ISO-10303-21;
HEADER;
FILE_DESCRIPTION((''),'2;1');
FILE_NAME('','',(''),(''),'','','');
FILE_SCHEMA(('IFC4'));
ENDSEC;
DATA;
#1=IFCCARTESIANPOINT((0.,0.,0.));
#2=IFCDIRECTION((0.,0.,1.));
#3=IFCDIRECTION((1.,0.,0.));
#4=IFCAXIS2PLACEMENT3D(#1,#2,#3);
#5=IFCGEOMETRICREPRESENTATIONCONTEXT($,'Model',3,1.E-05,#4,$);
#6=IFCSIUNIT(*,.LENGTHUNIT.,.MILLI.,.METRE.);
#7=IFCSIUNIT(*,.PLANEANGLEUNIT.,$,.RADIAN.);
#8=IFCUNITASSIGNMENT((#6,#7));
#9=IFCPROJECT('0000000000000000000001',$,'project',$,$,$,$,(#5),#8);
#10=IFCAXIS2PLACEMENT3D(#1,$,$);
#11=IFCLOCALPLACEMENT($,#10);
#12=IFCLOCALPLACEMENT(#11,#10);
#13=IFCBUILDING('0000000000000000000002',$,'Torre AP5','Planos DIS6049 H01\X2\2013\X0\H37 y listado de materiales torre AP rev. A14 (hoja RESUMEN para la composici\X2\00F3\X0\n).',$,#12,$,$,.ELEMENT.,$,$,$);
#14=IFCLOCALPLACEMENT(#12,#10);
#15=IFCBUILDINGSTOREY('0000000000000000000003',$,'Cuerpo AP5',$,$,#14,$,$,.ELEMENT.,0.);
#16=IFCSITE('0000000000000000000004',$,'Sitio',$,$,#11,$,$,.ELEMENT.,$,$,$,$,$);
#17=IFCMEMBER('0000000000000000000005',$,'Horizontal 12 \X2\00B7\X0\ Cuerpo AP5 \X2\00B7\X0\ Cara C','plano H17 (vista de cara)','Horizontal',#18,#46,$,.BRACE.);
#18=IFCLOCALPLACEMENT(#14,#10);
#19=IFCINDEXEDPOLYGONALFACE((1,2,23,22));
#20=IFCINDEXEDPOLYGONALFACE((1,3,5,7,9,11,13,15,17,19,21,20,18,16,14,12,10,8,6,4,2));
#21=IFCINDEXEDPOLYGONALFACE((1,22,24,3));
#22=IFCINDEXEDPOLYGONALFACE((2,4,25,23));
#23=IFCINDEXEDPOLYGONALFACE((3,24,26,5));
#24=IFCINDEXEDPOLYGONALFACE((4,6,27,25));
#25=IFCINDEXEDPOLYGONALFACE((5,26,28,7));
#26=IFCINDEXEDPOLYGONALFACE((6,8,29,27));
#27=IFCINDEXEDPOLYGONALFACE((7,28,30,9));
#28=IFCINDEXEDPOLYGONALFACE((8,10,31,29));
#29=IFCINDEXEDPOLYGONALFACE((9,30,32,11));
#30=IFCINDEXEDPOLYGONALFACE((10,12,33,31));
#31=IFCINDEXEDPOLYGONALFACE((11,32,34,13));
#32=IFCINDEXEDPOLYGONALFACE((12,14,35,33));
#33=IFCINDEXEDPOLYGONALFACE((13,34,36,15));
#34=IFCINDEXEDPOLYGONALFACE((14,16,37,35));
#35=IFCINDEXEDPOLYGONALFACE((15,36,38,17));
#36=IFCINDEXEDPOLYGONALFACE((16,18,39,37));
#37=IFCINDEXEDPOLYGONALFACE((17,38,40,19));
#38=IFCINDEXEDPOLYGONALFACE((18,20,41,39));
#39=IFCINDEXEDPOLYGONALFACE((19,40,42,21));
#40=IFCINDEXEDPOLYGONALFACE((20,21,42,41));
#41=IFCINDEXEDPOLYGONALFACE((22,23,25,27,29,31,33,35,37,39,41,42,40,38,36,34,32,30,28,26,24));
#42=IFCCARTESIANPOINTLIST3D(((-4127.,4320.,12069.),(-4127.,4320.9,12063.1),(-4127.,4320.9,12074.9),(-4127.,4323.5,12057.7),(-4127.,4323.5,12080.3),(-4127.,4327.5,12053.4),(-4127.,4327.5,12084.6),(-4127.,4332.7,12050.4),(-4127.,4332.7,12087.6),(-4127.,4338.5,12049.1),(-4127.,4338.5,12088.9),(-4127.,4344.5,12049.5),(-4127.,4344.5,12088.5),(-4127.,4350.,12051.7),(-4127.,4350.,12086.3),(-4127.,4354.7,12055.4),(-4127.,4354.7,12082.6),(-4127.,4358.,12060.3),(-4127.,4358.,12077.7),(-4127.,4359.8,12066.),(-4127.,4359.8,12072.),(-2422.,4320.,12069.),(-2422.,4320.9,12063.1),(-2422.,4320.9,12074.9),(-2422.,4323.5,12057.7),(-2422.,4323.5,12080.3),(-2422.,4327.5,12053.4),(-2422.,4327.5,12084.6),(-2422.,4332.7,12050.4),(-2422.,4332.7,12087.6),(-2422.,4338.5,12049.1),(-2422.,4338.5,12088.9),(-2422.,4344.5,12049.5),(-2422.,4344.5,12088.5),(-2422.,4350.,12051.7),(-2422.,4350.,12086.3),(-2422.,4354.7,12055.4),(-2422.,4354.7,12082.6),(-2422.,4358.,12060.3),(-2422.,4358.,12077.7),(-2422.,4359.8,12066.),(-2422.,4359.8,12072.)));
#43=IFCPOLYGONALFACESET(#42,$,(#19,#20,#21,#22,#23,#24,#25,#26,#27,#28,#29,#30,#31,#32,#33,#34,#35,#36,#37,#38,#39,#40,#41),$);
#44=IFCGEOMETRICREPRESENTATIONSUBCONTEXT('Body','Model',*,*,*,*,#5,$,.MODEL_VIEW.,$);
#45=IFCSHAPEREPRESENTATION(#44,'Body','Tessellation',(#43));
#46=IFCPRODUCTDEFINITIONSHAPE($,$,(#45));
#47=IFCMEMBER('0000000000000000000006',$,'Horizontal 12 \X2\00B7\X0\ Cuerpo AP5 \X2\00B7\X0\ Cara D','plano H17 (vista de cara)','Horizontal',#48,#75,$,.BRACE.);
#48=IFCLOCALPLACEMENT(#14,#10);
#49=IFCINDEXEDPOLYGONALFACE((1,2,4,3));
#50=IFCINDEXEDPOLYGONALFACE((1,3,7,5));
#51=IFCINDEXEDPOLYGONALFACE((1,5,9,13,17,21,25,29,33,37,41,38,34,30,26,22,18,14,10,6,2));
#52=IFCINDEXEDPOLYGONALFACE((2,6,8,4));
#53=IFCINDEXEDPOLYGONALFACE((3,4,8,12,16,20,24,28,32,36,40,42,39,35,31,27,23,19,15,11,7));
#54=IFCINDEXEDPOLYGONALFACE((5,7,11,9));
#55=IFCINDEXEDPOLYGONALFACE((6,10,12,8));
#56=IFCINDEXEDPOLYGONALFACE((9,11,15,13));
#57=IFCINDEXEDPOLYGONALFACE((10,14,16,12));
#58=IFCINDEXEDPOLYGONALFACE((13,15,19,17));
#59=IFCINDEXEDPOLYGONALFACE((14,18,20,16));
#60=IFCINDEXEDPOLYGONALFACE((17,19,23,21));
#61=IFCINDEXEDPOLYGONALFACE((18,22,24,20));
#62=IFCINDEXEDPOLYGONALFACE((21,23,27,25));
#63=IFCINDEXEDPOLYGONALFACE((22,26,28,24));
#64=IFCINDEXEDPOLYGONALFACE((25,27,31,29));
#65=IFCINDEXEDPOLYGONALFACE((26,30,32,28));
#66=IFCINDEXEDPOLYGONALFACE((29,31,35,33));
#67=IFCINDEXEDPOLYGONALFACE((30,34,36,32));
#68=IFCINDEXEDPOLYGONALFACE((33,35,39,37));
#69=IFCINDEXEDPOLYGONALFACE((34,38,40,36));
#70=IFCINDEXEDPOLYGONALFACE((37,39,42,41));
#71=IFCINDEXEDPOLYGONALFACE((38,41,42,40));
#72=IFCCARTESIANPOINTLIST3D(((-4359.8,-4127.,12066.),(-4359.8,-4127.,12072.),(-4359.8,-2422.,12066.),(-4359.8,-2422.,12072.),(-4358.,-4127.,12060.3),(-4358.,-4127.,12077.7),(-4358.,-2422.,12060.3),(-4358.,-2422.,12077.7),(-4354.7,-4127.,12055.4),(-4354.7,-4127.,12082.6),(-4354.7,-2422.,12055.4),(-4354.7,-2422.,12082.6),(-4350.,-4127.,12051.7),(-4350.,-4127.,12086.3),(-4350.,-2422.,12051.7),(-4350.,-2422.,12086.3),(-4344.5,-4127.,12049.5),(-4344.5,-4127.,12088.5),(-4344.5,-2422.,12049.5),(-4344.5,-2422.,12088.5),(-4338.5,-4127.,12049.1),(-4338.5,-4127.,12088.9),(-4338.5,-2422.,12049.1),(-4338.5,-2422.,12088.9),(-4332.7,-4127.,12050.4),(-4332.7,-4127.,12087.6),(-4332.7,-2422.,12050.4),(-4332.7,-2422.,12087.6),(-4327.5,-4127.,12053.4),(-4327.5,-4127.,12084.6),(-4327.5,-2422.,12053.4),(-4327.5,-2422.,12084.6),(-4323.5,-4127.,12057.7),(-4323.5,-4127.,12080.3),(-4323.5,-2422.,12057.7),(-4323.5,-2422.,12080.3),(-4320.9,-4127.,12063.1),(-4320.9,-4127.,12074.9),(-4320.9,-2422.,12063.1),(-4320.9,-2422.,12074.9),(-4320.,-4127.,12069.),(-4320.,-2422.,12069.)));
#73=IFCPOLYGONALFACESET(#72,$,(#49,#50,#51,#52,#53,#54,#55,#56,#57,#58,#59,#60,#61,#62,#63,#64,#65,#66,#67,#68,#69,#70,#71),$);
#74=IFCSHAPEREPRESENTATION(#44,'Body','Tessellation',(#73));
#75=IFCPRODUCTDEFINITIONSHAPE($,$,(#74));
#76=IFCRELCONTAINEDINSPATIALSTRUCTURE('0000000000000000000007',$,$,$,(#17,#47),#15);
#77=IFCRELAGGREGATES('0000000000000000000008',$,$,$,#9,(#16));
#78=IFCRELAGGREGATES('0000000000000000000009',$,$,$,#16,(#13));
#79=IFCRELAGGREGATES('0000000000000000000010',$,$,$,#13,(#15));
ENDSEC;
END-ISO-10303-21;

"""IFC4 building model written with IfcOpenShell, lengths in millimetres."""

from ifc_helpers import new_model, si_unit, frame, origin, origin_with_axes, place, context, subcontext, project, spatial, circle, extrude, element, save


model = new_model("IFC4")

# Units and contexts
model_context = context("Model", 3, precision=1e-05, world=origin_with_axes())
body_context = subcontext(model_context, "Body", "Model", "MODEL_VIEW")
ifc_project = project(units=[si_unit("LENGTHUNIT", "METRE", prefix="MILLI"), si_unit("PLANEANGLEUNIT", "RADIAN")], contexts=[model_context])

# Site, building, storey
site_placement = place(None, origin())
site = spatial("IfcSite", under=ifc_project, at=site_placement, Name="Sitio", CompositionType="ELEMENT")
building_placement = place(site_placement, origin())
building = spatial("IfcBuilding", under=site, at=building_placement, Name="Torre AP5", Description="Planos DIS6049 H01–H37 y listado de materiales torre AP rev. A14 (hoja RESUMEN para la composición).", CompositionType="ELEMENT")
storey_placement = place(building_placement, origin())
storey = spatial("IfcBuildingStorey", under=building, at=storey_placement, Name="Cuerpo AP5", CompositionType="ELEMENT", Elevation=0.0)

# Members
for number, where, z_axis, x_axis, name in (
    (1, (-4127.0, 4340.0, 12069.0), (1.0, 0.0, 0.0), (0.0, -1.0, 0.0), "Horizontal 12 · Cuerpo AP5 · Cara C"),
    (2, (-4340.0, -4127.0, 12069.0), (0.0, 1.0, 0.0), (1.0, 0.0, 0.0), "Horizontal 12 · Cuerpo AP5 · Cara D"),
):
    element("IfcMember", number, at=place(storey_placement, frame(where, z_axis=z_axis, x_axis=x_axis)), inside=storey, Name=name, Description="plano H17 (vista de cara)", ObjectType="Horizontal", PredefinedType="BRACE", context=body_context, shape_type="SweptSolid", body=[
        extrude(circle(Radius=20.0), None, (0.0, 0.0, 1.0), 1705.0),
    ])

save(model, "model.ifc")
